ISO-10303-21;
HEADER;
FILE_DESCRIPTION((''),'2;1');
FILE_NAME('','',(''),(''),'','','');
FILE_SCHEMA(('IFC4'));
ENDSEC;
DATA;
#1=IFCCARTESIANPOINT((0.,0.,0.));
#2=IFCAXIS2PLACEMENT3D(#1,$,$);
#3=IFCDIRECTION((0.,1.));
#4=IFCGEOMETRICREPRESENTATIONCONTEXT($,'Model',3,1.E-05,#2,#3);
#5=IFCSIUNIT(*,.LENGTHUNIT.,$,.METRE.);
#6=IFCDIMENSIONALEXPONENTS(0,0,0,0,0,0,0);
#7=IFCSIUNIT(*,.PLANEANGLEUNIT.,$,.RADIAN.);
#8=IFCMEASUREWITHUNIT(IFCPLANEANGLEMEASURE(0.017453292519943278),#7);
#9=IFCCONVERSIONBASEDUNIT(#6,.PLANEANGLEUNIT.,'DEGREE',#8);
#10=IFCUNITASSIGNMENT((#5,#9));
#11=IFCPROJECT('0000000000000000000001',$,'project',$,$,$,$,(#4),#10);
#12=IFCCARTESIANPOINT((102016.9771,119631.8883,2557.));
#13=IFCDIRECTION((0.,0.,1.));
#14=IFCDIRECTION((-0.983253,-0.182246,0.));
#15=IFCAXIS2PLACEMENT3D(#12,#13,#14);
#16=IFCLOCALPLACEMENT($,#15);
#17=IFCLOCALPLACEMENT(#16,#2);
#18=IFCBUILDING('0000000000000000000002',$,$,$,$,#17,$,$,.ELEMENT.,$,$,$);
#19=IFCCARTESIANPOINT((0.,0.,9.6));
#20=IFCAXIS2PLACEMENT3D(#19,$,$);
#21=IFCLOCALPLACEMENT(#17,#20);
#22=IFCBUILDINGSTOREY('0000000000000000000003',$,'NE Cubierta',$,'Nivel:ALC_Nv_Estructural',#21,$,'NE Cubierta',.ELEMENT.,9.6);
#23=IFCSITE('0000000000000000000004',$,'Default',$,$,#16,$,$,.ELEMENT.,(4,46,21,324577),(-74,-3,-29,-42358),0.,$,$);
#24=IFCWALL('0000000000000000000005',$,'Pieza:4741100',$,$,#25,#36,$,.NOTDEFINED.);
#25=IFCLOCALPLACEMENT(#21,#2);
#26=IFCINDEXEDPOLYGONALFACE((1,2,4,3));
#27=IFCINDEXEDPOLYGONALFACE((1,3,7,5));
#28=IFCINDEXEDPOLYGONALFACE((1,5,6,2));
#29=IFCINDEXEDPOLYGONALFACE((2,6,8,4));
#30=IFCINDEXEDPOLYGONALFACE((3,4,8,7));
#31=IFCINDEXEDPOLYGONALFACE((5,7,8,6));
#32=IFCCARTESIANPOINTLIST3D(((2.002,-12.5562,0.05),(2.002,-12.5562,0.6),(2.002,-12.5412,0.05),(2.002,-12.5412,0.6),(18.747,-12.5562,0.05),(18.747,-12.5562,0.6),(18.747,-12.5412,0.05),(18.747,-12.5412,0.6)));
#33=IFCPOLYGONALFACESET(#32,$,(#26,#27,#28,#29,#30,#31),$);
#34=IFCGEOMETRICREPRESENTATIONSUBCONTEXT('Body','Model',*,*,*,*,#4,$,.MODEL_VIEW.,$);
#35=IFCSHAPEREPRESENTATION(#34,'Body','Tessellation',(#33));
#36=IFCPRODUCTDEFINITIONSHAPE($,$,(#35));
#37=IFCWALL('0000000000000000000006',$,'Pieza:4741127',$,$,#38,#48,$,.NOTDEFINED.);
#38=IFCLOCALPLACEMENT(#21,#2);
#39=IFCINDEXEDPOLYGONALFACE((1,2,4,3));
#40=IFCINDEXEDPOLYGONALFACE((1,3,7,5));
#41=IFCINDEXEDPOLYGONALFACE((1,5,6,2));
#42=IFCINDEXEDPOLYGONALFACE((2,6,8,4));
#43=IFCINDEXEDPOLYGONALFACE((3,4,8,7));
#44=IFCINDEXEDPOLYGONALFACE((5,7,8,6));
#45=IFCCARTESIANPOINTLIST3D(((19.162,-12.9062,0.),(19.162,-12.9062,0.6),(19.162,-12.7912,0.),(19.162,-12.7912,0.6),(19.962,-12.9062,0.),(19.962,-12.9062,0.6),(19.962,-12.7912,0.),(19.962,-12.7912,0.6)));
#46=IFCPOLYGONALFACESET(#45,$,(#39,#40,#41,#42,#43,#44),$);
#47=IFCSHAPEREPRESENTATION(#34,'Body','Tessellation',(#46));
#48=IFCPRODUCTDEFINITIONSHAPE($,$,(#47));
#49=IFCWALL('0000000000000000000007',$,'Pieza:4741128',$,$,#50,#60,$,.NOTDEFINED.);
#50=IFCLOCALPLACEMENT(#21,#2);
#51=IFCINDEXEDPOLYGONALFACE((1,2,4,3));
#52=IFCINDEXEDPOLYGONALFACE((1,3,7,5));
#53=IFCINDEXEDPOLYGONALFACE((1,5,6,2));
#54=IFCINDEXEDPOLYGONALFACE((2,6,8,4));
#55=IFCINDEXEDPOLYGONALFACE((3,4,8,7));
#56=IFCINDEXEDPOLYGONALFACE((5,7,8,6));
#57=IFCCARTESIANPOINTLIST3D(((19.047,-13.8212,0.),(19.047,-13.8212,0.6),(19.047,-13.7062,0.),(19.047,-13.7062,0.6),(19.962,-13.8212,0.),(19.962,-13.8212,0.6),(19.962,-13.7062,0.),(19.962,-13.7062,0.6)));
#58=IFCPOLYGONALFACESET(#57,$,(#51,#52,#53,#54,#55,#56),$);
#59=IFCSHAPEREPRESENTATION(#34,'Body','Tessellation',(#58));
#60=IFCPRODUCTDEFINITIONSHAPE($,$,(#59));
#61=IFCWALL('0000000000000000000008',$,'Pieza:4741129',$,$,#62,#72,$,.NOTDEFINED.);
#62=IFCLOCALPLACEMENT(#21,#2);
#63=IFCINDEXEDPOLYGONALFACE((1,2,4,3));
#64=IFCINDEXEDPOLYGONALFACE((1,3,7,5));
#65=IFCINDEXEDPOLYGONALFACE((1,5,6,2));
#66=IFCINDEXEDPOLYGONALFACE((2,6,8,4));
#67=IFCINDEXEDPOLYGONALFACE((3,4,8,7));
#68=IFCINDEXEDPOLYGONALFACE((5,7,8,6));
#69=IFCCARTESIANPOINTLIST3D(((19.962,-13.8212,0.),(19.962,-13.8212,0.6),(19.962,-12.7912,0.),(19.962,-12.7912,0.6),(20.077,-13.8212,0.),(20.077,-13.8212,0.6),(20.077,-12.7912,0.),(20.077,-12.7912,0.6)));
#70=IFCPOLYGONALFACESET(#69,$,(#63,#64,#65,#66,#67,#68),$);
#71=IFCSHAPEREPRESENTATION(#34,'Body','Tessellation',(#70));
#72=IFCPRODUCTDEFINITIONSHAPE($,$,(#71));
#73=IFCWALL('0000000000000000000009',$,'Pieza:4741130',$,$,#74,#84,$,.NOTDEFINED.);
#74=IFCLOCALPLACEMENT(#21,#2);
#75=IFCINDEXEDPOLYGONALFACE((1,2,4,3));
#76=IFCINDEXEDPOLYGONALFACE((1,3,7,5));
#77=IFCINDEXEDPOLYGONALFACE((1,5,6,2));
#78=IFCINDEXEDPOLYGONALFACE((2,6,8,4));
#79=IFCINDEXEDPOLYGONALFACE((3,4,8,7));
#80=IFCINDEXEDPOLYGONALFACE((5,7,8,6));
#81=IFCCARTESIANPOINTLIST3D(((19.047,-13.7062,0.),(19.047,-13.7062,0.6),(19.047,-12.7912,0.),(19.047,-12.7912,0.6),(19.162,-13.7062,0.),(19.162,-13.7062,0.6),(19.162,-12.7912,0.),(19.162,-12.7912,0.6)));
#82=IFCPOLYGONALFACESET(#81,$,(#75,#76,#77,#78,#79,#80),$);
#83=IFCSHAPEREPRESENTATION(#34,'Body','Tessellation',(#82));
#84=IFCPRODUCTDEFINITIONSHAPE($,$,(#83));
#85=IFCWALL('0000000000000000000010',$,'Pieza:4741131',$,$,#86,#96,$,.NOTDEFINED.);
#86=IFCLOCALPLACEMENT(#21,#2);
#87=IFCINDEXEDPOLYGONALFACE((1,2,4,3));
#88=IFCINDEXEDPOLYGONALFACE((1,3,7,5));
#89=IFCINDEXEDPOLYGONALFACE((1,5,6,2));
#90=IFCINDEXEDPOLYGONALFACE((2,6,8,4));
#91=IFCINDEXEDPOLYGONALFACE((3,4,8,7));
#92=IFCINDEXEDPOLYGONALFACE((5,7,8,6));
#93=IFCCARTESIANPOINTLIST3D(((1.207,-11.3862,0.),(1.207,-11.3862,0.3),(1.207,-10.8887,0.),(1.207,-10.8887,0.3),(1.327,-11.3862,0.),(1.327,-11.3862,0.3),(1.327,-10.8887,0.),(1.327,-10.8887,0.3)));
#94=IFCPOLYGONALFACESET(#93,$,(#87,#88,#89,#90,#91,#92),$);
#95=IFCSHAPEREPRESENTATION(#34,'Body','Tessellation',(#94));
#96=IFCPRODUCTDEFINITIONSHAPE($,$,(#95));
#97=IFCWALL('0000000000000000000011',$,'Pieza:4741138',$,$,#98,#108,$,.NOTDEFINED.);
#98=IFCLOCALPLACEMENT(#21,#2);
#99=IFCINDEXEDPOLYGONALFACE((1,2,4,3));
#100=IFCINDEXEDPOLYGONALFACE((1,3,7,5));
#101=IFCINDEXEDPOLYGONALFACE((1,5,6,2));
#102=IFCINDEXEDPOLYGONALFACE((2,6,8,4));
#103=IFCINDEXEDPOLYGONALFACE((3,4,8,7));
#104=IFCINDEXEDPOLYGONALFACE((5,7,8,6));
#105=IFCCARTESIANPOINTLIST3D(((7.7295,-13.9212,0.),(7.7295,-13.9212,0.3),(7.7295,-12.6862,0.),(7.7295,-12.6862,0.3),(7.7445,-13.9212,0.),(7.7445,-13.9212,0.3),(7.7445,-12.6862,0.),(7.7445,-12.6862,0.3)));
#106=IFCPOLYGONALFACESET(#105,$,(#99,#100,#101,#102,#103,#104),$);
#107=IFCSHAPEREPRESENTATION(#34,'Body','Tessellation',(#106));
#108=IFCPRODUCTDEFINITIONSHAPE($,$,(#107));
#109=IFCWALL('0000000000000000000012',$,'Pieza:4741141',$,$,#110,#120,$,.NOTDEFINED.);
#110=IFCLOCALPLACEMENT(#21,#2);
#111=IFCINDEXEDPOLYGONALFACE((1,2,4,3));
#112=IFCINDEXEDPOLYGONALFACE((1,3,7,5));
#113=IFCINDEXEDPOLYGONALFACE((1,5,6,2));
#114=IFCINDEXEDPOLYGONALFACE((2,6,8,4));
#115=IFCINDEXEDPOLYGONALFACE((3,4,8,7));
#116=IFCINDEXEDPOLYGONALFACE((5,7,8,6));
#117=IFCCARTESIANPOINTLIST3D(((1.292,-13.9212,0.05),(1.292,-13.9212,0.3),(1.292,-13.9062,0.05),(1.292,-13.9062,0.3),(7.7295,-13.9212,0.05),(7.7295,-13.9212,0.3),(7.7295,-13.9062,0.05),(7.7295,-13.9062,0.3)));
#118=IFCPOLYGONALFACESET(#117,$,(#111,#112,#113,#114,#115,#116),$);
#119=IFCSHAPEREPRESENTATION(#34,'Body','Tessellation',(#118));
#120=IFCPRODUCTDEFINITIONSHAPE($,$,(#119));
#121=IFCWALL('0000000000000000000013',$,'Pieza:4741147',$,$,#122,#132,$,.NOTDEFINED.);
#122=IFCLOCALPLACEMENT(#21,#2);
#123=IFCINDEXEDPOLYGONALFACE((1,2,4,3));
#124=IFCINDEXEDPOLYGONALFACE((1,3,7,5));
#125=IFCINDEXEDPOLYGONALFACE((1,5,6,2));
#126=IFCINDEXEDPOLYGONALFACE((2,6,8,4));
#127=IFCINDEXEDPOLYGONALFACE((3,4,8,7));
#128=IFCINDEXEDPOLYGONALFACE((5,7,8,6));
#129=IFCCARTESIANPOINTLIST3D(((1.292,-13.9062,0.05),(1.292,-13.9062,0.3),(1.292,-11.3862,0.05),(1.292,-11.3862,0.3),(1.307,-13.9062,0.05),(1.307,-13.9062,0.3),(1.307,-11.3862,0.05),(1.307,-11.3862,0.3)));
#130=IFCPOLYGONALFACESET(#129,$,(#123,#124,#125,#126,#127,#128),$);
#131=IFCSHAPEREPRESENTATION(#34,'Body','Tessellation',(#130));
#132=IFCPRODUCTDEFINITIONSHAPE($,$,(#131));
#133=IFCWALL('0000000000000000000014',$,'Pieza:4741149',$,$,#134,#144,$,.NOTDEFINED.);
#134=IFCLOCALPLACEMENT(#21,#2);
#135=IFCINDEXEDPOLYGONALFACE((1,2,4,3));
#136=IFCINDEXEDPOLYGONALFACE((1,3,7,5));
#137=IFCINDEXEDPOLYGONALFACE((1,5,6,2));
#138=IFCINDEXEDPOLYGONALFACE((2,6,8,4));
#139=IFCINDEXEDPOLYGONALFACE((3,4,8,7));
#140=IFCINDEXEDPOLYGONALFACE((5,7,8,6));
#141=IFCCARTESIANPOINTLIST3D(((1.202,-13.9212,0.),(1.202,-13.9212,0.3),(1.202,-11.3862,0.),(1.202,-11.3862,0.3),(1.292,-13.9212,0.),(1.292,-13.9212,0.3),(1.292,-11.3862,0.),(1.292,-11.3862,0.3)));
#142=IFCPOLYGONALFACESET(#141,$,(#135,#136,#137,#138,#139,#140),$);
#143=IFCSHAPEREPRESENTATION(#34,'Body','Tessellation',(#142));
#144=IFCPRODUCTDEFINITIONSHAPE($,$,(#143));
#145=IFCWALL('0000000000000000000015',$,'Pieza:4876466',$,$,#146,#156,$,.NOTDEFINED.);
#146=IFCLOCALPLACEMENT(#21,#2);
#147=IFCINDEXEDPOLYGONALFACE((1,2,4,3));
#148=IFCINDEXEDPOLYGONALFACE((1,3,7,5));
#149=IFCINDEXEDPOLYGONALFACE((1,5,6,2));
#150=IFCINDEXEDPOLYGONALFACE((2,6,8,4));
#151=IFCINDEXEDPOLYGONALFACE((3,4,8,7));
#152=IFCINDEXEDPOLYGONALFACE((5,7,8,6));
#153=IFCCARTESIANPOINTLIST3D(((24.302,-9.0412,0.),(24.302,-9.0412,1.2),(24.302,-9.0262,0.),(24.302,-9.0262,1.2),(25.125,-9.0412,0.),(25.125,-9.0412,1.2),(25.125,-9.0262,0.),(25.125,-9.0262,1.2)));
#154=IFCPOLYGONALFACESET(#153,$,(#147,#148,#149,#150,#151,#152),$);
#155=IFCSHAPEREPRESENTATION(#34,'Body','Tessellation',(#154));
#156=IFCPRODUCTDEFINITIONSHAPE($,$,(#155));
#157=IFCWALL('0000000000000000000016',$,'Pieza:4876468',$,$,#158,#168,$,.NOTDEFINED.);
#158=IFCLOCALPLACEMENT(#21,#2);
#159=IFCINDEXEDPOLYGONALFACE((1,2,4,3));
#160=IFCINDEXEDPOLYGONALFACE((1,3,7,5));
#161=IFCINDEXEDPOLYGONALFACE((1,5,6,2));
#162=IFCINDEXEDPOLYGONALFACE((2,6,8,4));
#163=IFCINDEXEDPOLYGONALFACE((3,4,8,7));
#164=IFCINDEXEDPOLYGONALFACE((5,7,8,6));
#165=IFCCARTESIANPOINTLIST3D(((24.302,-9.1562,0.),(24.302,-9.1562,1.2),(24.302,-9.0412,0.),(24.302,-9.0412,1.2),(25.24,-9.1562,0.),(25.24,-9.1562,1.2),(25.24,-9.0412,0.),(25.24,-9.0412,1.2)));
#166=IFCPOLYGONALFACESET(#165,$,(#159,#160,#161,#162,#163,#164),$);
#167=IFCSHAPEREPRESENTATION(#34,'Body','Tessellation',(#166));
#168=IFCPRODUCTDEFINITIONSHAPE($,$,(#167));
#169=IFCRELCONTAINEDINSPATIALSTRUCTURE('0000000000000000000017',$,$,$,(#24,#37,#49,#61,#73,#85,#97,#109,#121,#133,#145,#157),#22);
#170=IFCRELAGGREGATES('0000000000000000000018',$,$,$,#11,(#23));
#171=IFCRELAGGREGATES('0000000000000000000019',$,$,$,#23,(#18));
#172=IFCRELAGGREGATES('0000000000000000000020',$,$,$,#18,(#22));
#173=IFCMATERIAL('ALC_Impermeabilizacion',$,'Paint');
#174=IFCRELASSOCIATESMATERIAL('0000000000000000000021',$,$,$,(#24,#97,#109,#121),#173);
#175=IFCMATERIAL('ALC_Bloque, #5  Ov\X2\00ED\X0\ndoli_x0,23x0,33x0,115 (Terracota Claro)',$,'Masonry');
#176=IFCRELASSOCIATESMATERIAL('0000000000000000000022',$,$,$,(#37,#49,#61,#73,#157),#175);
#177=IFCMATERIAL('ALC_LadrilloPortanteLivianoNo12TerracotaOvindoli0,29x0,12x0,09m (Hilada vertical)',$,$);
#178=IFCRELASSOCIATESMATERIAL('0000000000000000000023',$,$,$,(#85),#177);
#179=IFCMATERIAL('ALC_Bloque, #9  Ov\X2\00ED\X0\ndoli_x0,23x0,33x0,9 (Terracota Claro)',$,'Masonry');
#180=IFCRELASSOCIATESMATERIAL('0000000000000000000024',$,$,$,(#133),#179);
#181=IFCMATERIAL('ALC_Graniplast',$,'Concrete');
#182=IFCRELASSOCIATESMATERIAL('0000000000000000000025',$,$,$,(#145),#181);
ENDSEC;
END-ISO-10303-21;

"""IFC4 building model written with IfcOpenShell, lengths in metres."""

from ifc_helpers import new_model, entity, si_unit, converted_unit, direction, frame, frame_2d, origin, origin_2d_with_axis, place, context, subcontext, project, spatial, rectangle, extrude, material, element, save


model = new_model("IFC4")

# Units and contexts
model_context = context("Model", 3, precision=1e-05, world=origin(), true_north=direction((0.0, 1.0)))
body_context = subcontext(model_context, "Body", "Model", "MODEL_VIEW")
ifc_project = project(units=[si_unit("LENGTHUNIT", "METRE"), converted_unit("PLANEANGLEUNIT", "DEGREE", entity("IfcPlaneAngleMeasure", 0.017453292519943278), si_unit("PLANEANGLEUNIT", "RADIAN"), dimensions=[0, 0, 0, 0, 0, 0, 0])], contexts=[model_context])

# Site, building, storey
site_placement = place(None, frame((102016.9771, 119631.8883, 2557.0), z_axis=(0.0, 0.0, 1.0), x_axis=(-0.983253, -0.182246, 0.0)))
site = spatial("IfcSite", under=ifc_project, at=site_placement, Name="Default", CompositionType="ELEMENT", RefLatitude=(4, 46, 21, 324577), RefLongitude=(-74, -3, -29, -42358), RefElevation=0.0)
building_placement = place(site_placement, origin())
building = spatial("IfcBuilding", under=site, at=building_placement, CompositionType="ELEMENT")
storey_placement = place(building_placement, frame((0.0, 0.0, 9.6)))
storey = spatial("IfcBuildingStorey", under=building, at=storey_placement, Name="NE Cubierta", ObjectType="Nivel:ALC_Nv_Estructural", LongName="NE Cubierta", CompositionType="ELEMENT", Elevation=9.6)

# Walls
ifc_material_1 = material(Name="ALC_Impermeabilizacion", Category="Paint")
wall_1_placement = place(storey_placement, frame((0.0, 0.0, 0.05)))
element("IfcWall", 1, at=wall_1_placement, inside=storey, material=ifc_material_1, Name="Pieza:4741100", PredefinedType="NOTDEFINED", context=body_context, shape_type="SweptSolid", body=[
    extrude(rectangle(XDim=0.015, YDim=16.745, at=frame_2d((0.0, 0.0), x_axis=(1.0, 0.0))), frame((10.3745, -12.5487, 0.0), z_axis=(0.0, 0.0, 1.0), x_axis=(0.0, -1.0, 0.0)), (0.0, 0.0, 1.0), 0.55),
])
ifc_material_2 = material(Name="ALC_Bloque, #5  Ovíndoli_x0,23x0,33x0,115 (Terracota Claro)", Category="Masonry")
wall_2_placement = place(storey_placement, origin())
element("IfcWall", 2, at=wall_2_placement, inside=storey, material=ifc_material_2, Name="Pieza:4741127", PredefinedType="NOTDEFINED", context=body_context, shape_type="SweptSolid", body=[
    extrude(rectangle(XDim=0.115, YDim=0.8, at=frame_2d((0.0, 0.0), x_axis=(1.0, 0.0))), frame((19.562, -12.8487, 0.0), z_axis=(0.0, 0.0, 1.0), x_axis=(0.0, -1.0, 0.0)), (0.0, 0.0, 1.0), 0.6),
])
wall_3_placement = place(storey_placement, origin())
element("IfcWall", 3, at=wall_3_placement, inside=storey, material=ifc_material_2, Name="Pieza:4741128", PredefinedType="NOTDEFINED", context=body_context, shape_type="SweptSolid", body=[
    extrude(rectangle(XDim=0.115, YDim=0.915, at=frame_2d((0.0, 0.0), x_axis=(1.0, 0.0))), frame((19.5045, -13.7637, 0.0), z_axis=(0.0, 0.0, 1.0), x_axis=(0.0, -1.0, 0.0)), (0.0, 0.0, 1.0), 0.6),
])
wall_4_placement = place(storey_placement, origin())
element("IfcWall", 4, at=wall_4_placement, inside=storey, material=ifc_material_2, Name="Pieza:4741129", PredefinedType="NOTDEFINED", context=body_context, shape_type="SweptSolid", body=[
    extrude(rectangle(XDim=1.03, YDim=0.115, at=frame_2d((0.0, 0.0), x_axis=(1.0, 0.0))), frame((20.0195, -13.3062, 0.0), z_axis=(0.0, 0.0, 1.0), x_axis=(0.0, -1.0, 0.0)), (0.0, 0.0, 1.0), 0.6),
])
wall_5_placement = place(storey_placement, origin())
element("IfcWall", 5, at=wall_5_placement, inside=storey, material=ifc_material_2, Name="Pieza:4741130", PredefinedType="NOTDEFINED", context=body_context, shape_type="SweptSolid", body=[
    extrude(rectangle(XDim=0.915, YDim=0.115, at=origin_2d_with_axis()), frame((19.1045, -13.2487, 0.0), z_axis=(0.0, 0.0, 1.0), x_axis=(0.0, -1.0, 0.0)), (0.0, 0.0, 1.0), 0.6),
])
ifc_material_3 = material(Name="ALC_LadrilloPortanteLivianoNo12TerracotaOvindoli0,29x0,12x0,09m (Hilada vertical)")
wall_6_placement = place(storey_placement, origin())
element("IfcWall", 6, at=wall_6_placement, inside=storey, material=ifc_material_3, Name="Pieza:4741131", PredefinedType="NOTDEFINED", context=body_context, shape_type="SweptSolid", body=[
    extrude(rectangle(XDim=0.4975, YDim=0.12, at=frame_2d((0.0, 0.0), x_axis=(1.0, 0.0))), frame((1.267, -11.1374, 0.0), z_axis=(0.0, 0.0, 1.0), x_axis=(0.0, -1.0, 0.0)), (0.0, 0.0, 1.0), 0.3),
])
wall_7_placement = place(storey_placement, origin())
element("IfcWall", 7, at=wall_7_placement, inside=storey, material=ifc_material_1, Name="Pieza:4741138", PredefinedType="NOTDEFINED", context=body_context, shape_type="SweptSolid", body=[
    extrude(rectangle(XDim=1.235, YDim=0.015, at=frame_2d((0.0, 0.0), x_axis=(1.0, 0.0))), frame((7.737, -13.3037, 0.0), z_axis=(0.0, 0.0, 1.0), x_axis=(0.0, -1.0, 0.0)), (0.0, 0.0, 1.0), 0.3),
])
wall_8_placement = place(storey_placement, frame((0.0, 0.0, 0.05)))
element("IfcWall", 8, at=wall_8_placement, inside=storey, material=ifc_material_1, Name="Pieza:4741141", PredefinedType="NOTDEFINED", context=body_context, shape_type="SweptSolid", body=[
    extrude(rectangle(XDim=0.015, YDim=6.4375, at=frame_2d((0.0, 0.0), x_axis=(1.0, 0.0))), frame((4.5108, -13.9137, 0.0), z_axis=(0.0, 0.0, 1.0), x_axis=(0.0, -1.0, 0.0)), (0.0, 0.0, 1.0), 0.25),
])
wall_9_placement = place(storey_placement, frame((0.0, 0.0, 0.05)))
element("IfcWall", 9, at=wall_9_placement, inside=storey, material=ifc_material_1, Name="Pieza:4741147", PredefinedType="NOTDEFINED", context=body_context, shape_type="SweptSolid", body=[
    extrude(rectangle(XDim=2.52, YDim=0.015, at=frame_2d((0.0, 0.0), x_axis=(1.0, 0.0))), frame((1.2995, -12.6462, 0.0), z_axis=(0.0, 0.0, 1.0), x_axis=(0.0, -1.0, 0.0)), (0.0, 0.0, 1.0), 0.25),
])
ifc_material_4 = material(Name="ALC_Bloque, #9  Ovíndoli_x0,23x0,33x0,9 (Terracota Claro)", Category="Masonry")
wall_10_placement = place(storey_placement, origin())
element("IfcWall", 10, at=wall_10_placement, inside=storey, material=ifc_material_4, Name="Pieza:4741149", PredefinedType="NOTDEFINED", context=body_context, shape_type="SweptSolid", body=[
    extrude(rectangle(XDim=2.535, YDim=0.09, at=frame_2d((0.0, 0.0), x_axis=(1.0, 0.0))), frame((1.247, -12.6537, 0.0), z_axis=(0.0, 0.0, 1.0), x_axis=(0.0, -1.0, 0.0)), (0.0, 0.0, 1.0), 0.3),
])
ifc_material_5 = material(Name="ALC_Graniplast", Category="Concrete")
wall_11_placement = place(storey_placement, origin())
element("IfcWall", 11, at=wall_11_placement, inside=storey, material=ifc_material_5, Name="Pieza:4876466", PredefinedType="NOTDEFINED", context=body_context, shape_type="SweptSolid", body=[
    extrude(rectangle(XDim=0.015, YDim=0.823, at=frame_2d((0.0, 0.0), x_axis=(1.0, 0.0))), frame((24.7135, -9.0337, 0.0), z_axis=(0.0, 0.0, 1.0), x_axis=(0.0, -1.0, 0.0)), (0.0, 0.0, 1.0), 1.2),
])
wall_12_placement = place(storey_placement, origin())
element("IfcWall", 12, at=wall_12_placement, inside=storey, material=ifc_material_2, Name="Pieza:4876468", PredefinedType="NOTDEFINED", context=body_context, shape_type="SweptSolid", body=[
    extrude(rectangle(XDim=0.115, YDim=0.938, at=frame_2d((0.0, 0.0), x_axis=(1.0, 0.0))), frame((24.771, -9.0987, 0.0), z_axis=(0.0, 0.0, 1.0), x_axis=(0.0, -1.0, 0.0)), (0.0, 0.0, 1.0), 1.2),
])

save(model, "model.ifc")
